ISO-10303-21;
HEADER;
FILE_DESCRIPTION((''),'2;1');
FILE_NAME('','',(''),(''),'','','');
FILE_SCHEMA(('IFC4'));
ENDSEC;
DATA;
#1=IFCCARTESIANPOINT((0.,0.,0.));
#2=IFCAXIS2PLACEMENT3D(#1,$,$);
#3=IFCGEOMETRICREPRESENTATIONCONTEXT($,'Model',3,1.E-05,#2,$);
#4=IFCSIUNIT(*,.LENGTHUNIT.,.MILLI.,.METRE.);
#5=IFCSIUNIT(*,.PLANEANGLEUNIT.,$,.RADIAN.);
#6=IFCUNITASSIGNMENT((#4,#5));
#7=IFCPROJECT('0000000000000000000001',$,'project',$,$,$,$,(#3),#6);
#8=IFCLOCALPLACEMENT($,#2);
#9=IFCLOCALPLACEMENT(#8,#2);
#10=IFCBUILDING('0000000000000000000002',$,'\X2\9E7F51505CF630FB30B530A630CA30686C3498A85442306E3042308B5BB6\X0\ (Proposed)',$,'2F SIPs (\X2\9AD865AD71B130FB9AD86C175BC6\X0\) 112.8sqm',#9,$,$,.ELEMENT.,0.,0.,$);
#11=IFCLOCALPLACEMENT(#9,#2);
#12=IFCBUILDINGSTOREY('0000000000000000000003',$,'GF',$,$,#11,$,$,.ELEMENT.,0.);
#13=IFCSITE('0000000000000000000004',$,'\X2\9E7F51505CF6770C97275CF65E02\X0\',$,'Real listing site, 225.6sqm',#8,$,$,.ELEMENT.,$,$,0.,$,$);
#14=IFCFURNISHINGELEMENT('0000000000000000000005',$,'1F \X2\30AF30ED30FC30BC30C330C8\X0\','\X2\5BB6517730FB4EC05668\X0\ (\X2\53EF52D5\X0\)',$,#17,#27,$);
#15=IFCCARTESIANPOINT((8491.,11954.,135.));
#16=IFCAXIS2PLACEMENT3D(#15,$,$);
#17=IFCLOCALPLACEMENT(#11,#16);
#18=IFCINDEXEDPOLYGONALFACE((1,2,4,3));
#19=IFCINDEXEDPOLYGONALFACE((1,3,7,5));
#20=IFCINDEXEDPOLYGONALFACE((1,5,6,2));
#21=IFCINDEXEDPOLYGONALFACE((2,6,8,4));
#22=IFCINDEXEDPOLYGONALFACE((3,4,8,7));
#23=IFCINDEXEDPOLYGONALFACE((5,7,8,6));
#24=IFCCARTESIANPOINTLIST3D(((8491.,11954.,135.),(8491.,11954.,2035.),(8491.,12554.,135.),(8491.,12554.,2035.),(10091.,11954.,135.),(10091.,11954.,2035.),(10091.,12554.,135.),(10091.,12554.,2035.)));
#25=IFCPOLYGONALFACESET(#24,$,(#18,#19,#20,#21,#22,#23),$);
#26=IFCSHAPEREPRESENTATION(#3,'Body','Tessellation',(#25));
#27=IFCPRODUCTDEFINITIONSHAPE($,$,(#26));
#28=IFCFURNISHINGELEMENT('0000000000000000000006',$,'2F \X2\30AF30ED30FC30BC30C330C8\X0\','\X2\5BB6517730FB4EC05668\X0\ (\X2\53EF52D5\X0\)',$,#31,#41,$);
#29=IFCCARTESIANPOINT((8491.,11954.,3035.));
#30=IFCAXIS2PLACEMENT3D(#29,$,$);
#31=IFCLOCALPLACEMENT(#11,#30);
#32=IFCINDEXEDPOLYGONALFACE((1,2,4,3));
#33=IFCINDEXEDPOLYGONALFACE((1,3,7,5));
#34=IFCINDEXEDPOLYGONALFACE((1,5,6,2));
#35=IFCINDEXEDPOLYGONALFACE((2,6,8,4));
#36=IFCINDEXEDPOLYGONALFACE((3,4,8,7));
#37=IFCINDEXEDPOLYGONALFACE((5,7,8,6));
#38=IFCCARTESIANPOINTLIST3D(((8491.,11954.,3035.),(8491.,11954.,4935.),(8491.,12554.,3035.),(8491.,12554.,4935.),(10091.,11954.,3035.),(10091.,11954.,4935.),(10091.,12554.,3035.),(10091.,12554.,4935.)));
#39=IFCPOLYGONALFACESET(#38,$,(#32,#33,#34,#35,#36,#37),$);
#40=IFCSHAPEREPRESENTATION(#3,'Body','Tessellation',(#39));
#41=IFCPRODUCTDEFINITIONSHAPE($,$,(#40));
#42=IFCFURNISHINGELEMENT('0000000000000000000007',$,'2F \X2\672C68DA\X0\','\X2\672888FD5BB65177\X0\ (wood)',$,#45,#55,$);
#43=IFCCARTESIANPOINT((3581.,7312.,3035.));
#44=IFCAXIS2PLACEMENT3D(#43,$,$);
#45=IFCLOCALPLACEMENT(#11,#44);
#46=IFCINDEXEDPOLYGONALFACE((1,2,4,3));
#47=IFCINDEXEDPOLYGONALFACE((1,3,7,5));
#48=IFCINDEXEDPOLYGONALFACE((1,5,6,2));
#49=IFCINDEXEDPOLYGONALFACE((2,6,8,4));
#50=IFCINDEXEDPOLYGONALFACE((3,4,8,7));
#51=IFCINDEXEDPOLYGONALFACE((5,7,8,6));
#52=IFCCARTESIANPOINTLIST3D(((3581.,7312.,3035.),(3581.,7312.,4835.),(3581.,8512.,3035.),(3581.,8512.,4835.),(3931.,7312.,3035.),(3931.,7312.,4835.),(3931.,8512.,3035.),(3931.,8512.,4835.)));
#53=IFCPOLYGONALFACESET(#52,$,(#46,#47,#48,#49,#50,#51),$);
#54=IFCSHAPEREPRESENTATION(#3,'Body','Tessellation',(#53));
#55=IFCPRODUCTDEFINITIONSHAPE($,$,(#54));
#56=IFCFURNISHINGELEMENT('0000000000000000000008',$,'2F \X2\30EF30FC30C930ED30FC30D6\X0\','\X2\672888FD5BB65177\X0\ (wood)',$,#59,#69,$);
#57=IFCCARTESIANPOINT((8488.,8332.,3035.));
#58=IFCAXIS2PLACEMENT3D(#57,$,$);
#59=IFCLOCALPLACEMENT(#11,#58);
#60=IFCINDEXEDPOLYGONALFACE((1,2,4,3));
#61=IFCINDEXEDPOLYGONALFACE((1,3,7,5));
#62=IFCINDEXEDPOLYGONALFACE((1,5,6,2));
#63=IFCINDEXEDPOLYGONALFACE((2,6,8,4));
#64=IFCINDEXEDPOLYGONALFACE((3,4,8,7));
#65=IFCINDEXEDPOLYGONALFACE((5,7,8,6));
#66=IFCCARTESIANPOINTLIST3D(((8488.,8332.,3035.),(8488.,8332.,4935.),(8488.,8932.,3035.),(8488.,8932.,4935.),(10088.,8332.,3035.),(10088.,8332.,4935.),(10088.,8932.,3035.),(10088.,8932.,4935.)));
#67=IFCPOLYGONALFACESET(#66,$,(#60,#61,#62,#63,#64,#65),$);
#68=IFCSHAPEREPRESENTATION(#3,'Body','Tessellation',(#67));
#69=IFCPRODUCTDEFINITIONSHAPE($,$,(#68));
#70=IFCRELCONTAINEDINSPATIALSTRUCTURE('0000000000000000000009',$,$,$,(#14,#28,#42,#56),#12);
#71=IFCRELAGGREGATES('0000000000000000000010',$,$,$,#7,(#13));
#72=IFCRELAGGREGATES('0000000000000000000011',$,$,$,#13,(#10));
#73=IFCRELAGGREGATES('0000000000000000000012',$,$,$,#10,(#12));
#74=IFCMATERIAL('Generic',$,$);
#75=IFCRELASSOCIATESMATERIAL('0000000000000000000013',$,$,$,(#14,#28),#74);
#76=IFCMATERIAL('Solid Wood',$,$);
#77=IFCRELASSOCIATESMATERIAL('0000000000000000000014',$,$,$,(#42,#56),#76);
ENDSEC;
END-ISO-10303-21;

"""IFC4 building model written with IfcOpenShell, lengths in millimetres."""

from ifc_helpers import new_model, si_unit, frame, frame_2d, origin, place, context, project, spatial, rectangle, extrude, material, element, save


model = new_model("IFC4")

# Units and contexts
model_context = context("Model", 3, precision=1e-05, world=origin())
ifc_project = project(units=[si_unit("LENGTHUNIT", "METRE", prefix="MILLI"), si_unit("PLANEANGLEUNIT", "RADIAN")], contexts=[model_context])

# Site, building, storey
site_placement = place(None, origin())
site = spatial("IfcSite", under=ifc_project, at=site_placement, Name="鹿児島県霧島市", ObjectType="Real listing site, 225.6sqm", CompositionType="ELEMENT", RefElevation=0.0)
building_placement = place(site_placement, origin())
building = spatial("IfcBuilding", under=site, at=building_placement, Name="鹿児島・サウナと水風呂のある家 (Proposed)", ObjectType="2F SIPs (高断熱・高気密) 112.8sqm", CompositionType="ELEMENT", ElevationOfRefHeight=0.0, ElevationOfTerrain=0.0)
storey_placement = place(building_placement, origin())
storey = spatial("IfcBuildingStorey", under=building, at=storey_placement, Name="GF", CompositionType="ELEMENT", Elevation=0.0)

# Shared definitions
ifc_material_1 = material(Name="Solid Wood")

# Shared definitions
ifc_material_2 = material(Name="Generic")

# Furnishing elements
furnishing_1_placement = place(storey_placement, frame((8491.0, 11954.0, 135.0)))
element("IfcFurnishingElement", 1, at=furnishing_1_placement, inside=storey, material=ifc_material_2, Name="1F クローゼット", Description="家具・什器 (可動)", context=model_context, shape_type="SweptSolid", body=[
    extrude(rectangle(XDim=1600.0, YDim=600.0, at=frame_2d((800.0, 300.0))), frame((8491.0, 11954.0, 135.0)), (0.0, 0.0, 1.0), 1900.0),
])
furnishing_2_placement = place(storey_placement, frame((8491.0, 11954.0, 3035.0)))
element("IfcFurnishingElement", 2, at=furnishing_2_placement, inside=storey, material=ifc_material_2, Name="2F クローゼット", Description="家具・什器 (可動)", context=model_context, shape_type="SweptSolid", body=[
    extrude(rectangle(XDim=1600.0, YDim=600.0, at=frame_2d((800.0, 300.0))), frame((8491.0, 11954.0, 3035.0)), (0.0, 0.0, 1.0), 1900.0),
])
furnishing_3_placement = place(storey_placement, frame((3581.0, 7312.0, 3035.0)))
element("IfcFurnishingElement", 3, at=furnishing_3_placement, inside=storey, material=ifc_material_1, Name="2F 本棚", Description="木製家具 (wood)", context=model_context, shape_type="SweptSolid", body=[
    extrude(rectangle(XDim=350.0, YDim=1200.0, at=frame_2d((175.0, 600.0))), frame((3581.0, 7312.0, 3035.0)), (0.0, 0.0, 1.0), 1800.0),
])
furnishing_4_placement = place(storey_placement, frame((8488.0, 8332.0, 3035.0)))
element("IfcFurnishingElement", 4, at=furnishing_4_placement, inside=storey, material=ifc_material_1, Name="2F ワードローブ", Description="木製家具 (wood)", context=model_context, shape_type="SweptSolid", body=[
    extrude(rectangle(XDim=1600.0, YDim=600.0, at=frame_2d((800.0, 300.0))), frame((8488.0, 8332.0, 3035.0)), (0.0, 0.0, 1.0), 1900.0),
])

save(model, "model.ifc")
